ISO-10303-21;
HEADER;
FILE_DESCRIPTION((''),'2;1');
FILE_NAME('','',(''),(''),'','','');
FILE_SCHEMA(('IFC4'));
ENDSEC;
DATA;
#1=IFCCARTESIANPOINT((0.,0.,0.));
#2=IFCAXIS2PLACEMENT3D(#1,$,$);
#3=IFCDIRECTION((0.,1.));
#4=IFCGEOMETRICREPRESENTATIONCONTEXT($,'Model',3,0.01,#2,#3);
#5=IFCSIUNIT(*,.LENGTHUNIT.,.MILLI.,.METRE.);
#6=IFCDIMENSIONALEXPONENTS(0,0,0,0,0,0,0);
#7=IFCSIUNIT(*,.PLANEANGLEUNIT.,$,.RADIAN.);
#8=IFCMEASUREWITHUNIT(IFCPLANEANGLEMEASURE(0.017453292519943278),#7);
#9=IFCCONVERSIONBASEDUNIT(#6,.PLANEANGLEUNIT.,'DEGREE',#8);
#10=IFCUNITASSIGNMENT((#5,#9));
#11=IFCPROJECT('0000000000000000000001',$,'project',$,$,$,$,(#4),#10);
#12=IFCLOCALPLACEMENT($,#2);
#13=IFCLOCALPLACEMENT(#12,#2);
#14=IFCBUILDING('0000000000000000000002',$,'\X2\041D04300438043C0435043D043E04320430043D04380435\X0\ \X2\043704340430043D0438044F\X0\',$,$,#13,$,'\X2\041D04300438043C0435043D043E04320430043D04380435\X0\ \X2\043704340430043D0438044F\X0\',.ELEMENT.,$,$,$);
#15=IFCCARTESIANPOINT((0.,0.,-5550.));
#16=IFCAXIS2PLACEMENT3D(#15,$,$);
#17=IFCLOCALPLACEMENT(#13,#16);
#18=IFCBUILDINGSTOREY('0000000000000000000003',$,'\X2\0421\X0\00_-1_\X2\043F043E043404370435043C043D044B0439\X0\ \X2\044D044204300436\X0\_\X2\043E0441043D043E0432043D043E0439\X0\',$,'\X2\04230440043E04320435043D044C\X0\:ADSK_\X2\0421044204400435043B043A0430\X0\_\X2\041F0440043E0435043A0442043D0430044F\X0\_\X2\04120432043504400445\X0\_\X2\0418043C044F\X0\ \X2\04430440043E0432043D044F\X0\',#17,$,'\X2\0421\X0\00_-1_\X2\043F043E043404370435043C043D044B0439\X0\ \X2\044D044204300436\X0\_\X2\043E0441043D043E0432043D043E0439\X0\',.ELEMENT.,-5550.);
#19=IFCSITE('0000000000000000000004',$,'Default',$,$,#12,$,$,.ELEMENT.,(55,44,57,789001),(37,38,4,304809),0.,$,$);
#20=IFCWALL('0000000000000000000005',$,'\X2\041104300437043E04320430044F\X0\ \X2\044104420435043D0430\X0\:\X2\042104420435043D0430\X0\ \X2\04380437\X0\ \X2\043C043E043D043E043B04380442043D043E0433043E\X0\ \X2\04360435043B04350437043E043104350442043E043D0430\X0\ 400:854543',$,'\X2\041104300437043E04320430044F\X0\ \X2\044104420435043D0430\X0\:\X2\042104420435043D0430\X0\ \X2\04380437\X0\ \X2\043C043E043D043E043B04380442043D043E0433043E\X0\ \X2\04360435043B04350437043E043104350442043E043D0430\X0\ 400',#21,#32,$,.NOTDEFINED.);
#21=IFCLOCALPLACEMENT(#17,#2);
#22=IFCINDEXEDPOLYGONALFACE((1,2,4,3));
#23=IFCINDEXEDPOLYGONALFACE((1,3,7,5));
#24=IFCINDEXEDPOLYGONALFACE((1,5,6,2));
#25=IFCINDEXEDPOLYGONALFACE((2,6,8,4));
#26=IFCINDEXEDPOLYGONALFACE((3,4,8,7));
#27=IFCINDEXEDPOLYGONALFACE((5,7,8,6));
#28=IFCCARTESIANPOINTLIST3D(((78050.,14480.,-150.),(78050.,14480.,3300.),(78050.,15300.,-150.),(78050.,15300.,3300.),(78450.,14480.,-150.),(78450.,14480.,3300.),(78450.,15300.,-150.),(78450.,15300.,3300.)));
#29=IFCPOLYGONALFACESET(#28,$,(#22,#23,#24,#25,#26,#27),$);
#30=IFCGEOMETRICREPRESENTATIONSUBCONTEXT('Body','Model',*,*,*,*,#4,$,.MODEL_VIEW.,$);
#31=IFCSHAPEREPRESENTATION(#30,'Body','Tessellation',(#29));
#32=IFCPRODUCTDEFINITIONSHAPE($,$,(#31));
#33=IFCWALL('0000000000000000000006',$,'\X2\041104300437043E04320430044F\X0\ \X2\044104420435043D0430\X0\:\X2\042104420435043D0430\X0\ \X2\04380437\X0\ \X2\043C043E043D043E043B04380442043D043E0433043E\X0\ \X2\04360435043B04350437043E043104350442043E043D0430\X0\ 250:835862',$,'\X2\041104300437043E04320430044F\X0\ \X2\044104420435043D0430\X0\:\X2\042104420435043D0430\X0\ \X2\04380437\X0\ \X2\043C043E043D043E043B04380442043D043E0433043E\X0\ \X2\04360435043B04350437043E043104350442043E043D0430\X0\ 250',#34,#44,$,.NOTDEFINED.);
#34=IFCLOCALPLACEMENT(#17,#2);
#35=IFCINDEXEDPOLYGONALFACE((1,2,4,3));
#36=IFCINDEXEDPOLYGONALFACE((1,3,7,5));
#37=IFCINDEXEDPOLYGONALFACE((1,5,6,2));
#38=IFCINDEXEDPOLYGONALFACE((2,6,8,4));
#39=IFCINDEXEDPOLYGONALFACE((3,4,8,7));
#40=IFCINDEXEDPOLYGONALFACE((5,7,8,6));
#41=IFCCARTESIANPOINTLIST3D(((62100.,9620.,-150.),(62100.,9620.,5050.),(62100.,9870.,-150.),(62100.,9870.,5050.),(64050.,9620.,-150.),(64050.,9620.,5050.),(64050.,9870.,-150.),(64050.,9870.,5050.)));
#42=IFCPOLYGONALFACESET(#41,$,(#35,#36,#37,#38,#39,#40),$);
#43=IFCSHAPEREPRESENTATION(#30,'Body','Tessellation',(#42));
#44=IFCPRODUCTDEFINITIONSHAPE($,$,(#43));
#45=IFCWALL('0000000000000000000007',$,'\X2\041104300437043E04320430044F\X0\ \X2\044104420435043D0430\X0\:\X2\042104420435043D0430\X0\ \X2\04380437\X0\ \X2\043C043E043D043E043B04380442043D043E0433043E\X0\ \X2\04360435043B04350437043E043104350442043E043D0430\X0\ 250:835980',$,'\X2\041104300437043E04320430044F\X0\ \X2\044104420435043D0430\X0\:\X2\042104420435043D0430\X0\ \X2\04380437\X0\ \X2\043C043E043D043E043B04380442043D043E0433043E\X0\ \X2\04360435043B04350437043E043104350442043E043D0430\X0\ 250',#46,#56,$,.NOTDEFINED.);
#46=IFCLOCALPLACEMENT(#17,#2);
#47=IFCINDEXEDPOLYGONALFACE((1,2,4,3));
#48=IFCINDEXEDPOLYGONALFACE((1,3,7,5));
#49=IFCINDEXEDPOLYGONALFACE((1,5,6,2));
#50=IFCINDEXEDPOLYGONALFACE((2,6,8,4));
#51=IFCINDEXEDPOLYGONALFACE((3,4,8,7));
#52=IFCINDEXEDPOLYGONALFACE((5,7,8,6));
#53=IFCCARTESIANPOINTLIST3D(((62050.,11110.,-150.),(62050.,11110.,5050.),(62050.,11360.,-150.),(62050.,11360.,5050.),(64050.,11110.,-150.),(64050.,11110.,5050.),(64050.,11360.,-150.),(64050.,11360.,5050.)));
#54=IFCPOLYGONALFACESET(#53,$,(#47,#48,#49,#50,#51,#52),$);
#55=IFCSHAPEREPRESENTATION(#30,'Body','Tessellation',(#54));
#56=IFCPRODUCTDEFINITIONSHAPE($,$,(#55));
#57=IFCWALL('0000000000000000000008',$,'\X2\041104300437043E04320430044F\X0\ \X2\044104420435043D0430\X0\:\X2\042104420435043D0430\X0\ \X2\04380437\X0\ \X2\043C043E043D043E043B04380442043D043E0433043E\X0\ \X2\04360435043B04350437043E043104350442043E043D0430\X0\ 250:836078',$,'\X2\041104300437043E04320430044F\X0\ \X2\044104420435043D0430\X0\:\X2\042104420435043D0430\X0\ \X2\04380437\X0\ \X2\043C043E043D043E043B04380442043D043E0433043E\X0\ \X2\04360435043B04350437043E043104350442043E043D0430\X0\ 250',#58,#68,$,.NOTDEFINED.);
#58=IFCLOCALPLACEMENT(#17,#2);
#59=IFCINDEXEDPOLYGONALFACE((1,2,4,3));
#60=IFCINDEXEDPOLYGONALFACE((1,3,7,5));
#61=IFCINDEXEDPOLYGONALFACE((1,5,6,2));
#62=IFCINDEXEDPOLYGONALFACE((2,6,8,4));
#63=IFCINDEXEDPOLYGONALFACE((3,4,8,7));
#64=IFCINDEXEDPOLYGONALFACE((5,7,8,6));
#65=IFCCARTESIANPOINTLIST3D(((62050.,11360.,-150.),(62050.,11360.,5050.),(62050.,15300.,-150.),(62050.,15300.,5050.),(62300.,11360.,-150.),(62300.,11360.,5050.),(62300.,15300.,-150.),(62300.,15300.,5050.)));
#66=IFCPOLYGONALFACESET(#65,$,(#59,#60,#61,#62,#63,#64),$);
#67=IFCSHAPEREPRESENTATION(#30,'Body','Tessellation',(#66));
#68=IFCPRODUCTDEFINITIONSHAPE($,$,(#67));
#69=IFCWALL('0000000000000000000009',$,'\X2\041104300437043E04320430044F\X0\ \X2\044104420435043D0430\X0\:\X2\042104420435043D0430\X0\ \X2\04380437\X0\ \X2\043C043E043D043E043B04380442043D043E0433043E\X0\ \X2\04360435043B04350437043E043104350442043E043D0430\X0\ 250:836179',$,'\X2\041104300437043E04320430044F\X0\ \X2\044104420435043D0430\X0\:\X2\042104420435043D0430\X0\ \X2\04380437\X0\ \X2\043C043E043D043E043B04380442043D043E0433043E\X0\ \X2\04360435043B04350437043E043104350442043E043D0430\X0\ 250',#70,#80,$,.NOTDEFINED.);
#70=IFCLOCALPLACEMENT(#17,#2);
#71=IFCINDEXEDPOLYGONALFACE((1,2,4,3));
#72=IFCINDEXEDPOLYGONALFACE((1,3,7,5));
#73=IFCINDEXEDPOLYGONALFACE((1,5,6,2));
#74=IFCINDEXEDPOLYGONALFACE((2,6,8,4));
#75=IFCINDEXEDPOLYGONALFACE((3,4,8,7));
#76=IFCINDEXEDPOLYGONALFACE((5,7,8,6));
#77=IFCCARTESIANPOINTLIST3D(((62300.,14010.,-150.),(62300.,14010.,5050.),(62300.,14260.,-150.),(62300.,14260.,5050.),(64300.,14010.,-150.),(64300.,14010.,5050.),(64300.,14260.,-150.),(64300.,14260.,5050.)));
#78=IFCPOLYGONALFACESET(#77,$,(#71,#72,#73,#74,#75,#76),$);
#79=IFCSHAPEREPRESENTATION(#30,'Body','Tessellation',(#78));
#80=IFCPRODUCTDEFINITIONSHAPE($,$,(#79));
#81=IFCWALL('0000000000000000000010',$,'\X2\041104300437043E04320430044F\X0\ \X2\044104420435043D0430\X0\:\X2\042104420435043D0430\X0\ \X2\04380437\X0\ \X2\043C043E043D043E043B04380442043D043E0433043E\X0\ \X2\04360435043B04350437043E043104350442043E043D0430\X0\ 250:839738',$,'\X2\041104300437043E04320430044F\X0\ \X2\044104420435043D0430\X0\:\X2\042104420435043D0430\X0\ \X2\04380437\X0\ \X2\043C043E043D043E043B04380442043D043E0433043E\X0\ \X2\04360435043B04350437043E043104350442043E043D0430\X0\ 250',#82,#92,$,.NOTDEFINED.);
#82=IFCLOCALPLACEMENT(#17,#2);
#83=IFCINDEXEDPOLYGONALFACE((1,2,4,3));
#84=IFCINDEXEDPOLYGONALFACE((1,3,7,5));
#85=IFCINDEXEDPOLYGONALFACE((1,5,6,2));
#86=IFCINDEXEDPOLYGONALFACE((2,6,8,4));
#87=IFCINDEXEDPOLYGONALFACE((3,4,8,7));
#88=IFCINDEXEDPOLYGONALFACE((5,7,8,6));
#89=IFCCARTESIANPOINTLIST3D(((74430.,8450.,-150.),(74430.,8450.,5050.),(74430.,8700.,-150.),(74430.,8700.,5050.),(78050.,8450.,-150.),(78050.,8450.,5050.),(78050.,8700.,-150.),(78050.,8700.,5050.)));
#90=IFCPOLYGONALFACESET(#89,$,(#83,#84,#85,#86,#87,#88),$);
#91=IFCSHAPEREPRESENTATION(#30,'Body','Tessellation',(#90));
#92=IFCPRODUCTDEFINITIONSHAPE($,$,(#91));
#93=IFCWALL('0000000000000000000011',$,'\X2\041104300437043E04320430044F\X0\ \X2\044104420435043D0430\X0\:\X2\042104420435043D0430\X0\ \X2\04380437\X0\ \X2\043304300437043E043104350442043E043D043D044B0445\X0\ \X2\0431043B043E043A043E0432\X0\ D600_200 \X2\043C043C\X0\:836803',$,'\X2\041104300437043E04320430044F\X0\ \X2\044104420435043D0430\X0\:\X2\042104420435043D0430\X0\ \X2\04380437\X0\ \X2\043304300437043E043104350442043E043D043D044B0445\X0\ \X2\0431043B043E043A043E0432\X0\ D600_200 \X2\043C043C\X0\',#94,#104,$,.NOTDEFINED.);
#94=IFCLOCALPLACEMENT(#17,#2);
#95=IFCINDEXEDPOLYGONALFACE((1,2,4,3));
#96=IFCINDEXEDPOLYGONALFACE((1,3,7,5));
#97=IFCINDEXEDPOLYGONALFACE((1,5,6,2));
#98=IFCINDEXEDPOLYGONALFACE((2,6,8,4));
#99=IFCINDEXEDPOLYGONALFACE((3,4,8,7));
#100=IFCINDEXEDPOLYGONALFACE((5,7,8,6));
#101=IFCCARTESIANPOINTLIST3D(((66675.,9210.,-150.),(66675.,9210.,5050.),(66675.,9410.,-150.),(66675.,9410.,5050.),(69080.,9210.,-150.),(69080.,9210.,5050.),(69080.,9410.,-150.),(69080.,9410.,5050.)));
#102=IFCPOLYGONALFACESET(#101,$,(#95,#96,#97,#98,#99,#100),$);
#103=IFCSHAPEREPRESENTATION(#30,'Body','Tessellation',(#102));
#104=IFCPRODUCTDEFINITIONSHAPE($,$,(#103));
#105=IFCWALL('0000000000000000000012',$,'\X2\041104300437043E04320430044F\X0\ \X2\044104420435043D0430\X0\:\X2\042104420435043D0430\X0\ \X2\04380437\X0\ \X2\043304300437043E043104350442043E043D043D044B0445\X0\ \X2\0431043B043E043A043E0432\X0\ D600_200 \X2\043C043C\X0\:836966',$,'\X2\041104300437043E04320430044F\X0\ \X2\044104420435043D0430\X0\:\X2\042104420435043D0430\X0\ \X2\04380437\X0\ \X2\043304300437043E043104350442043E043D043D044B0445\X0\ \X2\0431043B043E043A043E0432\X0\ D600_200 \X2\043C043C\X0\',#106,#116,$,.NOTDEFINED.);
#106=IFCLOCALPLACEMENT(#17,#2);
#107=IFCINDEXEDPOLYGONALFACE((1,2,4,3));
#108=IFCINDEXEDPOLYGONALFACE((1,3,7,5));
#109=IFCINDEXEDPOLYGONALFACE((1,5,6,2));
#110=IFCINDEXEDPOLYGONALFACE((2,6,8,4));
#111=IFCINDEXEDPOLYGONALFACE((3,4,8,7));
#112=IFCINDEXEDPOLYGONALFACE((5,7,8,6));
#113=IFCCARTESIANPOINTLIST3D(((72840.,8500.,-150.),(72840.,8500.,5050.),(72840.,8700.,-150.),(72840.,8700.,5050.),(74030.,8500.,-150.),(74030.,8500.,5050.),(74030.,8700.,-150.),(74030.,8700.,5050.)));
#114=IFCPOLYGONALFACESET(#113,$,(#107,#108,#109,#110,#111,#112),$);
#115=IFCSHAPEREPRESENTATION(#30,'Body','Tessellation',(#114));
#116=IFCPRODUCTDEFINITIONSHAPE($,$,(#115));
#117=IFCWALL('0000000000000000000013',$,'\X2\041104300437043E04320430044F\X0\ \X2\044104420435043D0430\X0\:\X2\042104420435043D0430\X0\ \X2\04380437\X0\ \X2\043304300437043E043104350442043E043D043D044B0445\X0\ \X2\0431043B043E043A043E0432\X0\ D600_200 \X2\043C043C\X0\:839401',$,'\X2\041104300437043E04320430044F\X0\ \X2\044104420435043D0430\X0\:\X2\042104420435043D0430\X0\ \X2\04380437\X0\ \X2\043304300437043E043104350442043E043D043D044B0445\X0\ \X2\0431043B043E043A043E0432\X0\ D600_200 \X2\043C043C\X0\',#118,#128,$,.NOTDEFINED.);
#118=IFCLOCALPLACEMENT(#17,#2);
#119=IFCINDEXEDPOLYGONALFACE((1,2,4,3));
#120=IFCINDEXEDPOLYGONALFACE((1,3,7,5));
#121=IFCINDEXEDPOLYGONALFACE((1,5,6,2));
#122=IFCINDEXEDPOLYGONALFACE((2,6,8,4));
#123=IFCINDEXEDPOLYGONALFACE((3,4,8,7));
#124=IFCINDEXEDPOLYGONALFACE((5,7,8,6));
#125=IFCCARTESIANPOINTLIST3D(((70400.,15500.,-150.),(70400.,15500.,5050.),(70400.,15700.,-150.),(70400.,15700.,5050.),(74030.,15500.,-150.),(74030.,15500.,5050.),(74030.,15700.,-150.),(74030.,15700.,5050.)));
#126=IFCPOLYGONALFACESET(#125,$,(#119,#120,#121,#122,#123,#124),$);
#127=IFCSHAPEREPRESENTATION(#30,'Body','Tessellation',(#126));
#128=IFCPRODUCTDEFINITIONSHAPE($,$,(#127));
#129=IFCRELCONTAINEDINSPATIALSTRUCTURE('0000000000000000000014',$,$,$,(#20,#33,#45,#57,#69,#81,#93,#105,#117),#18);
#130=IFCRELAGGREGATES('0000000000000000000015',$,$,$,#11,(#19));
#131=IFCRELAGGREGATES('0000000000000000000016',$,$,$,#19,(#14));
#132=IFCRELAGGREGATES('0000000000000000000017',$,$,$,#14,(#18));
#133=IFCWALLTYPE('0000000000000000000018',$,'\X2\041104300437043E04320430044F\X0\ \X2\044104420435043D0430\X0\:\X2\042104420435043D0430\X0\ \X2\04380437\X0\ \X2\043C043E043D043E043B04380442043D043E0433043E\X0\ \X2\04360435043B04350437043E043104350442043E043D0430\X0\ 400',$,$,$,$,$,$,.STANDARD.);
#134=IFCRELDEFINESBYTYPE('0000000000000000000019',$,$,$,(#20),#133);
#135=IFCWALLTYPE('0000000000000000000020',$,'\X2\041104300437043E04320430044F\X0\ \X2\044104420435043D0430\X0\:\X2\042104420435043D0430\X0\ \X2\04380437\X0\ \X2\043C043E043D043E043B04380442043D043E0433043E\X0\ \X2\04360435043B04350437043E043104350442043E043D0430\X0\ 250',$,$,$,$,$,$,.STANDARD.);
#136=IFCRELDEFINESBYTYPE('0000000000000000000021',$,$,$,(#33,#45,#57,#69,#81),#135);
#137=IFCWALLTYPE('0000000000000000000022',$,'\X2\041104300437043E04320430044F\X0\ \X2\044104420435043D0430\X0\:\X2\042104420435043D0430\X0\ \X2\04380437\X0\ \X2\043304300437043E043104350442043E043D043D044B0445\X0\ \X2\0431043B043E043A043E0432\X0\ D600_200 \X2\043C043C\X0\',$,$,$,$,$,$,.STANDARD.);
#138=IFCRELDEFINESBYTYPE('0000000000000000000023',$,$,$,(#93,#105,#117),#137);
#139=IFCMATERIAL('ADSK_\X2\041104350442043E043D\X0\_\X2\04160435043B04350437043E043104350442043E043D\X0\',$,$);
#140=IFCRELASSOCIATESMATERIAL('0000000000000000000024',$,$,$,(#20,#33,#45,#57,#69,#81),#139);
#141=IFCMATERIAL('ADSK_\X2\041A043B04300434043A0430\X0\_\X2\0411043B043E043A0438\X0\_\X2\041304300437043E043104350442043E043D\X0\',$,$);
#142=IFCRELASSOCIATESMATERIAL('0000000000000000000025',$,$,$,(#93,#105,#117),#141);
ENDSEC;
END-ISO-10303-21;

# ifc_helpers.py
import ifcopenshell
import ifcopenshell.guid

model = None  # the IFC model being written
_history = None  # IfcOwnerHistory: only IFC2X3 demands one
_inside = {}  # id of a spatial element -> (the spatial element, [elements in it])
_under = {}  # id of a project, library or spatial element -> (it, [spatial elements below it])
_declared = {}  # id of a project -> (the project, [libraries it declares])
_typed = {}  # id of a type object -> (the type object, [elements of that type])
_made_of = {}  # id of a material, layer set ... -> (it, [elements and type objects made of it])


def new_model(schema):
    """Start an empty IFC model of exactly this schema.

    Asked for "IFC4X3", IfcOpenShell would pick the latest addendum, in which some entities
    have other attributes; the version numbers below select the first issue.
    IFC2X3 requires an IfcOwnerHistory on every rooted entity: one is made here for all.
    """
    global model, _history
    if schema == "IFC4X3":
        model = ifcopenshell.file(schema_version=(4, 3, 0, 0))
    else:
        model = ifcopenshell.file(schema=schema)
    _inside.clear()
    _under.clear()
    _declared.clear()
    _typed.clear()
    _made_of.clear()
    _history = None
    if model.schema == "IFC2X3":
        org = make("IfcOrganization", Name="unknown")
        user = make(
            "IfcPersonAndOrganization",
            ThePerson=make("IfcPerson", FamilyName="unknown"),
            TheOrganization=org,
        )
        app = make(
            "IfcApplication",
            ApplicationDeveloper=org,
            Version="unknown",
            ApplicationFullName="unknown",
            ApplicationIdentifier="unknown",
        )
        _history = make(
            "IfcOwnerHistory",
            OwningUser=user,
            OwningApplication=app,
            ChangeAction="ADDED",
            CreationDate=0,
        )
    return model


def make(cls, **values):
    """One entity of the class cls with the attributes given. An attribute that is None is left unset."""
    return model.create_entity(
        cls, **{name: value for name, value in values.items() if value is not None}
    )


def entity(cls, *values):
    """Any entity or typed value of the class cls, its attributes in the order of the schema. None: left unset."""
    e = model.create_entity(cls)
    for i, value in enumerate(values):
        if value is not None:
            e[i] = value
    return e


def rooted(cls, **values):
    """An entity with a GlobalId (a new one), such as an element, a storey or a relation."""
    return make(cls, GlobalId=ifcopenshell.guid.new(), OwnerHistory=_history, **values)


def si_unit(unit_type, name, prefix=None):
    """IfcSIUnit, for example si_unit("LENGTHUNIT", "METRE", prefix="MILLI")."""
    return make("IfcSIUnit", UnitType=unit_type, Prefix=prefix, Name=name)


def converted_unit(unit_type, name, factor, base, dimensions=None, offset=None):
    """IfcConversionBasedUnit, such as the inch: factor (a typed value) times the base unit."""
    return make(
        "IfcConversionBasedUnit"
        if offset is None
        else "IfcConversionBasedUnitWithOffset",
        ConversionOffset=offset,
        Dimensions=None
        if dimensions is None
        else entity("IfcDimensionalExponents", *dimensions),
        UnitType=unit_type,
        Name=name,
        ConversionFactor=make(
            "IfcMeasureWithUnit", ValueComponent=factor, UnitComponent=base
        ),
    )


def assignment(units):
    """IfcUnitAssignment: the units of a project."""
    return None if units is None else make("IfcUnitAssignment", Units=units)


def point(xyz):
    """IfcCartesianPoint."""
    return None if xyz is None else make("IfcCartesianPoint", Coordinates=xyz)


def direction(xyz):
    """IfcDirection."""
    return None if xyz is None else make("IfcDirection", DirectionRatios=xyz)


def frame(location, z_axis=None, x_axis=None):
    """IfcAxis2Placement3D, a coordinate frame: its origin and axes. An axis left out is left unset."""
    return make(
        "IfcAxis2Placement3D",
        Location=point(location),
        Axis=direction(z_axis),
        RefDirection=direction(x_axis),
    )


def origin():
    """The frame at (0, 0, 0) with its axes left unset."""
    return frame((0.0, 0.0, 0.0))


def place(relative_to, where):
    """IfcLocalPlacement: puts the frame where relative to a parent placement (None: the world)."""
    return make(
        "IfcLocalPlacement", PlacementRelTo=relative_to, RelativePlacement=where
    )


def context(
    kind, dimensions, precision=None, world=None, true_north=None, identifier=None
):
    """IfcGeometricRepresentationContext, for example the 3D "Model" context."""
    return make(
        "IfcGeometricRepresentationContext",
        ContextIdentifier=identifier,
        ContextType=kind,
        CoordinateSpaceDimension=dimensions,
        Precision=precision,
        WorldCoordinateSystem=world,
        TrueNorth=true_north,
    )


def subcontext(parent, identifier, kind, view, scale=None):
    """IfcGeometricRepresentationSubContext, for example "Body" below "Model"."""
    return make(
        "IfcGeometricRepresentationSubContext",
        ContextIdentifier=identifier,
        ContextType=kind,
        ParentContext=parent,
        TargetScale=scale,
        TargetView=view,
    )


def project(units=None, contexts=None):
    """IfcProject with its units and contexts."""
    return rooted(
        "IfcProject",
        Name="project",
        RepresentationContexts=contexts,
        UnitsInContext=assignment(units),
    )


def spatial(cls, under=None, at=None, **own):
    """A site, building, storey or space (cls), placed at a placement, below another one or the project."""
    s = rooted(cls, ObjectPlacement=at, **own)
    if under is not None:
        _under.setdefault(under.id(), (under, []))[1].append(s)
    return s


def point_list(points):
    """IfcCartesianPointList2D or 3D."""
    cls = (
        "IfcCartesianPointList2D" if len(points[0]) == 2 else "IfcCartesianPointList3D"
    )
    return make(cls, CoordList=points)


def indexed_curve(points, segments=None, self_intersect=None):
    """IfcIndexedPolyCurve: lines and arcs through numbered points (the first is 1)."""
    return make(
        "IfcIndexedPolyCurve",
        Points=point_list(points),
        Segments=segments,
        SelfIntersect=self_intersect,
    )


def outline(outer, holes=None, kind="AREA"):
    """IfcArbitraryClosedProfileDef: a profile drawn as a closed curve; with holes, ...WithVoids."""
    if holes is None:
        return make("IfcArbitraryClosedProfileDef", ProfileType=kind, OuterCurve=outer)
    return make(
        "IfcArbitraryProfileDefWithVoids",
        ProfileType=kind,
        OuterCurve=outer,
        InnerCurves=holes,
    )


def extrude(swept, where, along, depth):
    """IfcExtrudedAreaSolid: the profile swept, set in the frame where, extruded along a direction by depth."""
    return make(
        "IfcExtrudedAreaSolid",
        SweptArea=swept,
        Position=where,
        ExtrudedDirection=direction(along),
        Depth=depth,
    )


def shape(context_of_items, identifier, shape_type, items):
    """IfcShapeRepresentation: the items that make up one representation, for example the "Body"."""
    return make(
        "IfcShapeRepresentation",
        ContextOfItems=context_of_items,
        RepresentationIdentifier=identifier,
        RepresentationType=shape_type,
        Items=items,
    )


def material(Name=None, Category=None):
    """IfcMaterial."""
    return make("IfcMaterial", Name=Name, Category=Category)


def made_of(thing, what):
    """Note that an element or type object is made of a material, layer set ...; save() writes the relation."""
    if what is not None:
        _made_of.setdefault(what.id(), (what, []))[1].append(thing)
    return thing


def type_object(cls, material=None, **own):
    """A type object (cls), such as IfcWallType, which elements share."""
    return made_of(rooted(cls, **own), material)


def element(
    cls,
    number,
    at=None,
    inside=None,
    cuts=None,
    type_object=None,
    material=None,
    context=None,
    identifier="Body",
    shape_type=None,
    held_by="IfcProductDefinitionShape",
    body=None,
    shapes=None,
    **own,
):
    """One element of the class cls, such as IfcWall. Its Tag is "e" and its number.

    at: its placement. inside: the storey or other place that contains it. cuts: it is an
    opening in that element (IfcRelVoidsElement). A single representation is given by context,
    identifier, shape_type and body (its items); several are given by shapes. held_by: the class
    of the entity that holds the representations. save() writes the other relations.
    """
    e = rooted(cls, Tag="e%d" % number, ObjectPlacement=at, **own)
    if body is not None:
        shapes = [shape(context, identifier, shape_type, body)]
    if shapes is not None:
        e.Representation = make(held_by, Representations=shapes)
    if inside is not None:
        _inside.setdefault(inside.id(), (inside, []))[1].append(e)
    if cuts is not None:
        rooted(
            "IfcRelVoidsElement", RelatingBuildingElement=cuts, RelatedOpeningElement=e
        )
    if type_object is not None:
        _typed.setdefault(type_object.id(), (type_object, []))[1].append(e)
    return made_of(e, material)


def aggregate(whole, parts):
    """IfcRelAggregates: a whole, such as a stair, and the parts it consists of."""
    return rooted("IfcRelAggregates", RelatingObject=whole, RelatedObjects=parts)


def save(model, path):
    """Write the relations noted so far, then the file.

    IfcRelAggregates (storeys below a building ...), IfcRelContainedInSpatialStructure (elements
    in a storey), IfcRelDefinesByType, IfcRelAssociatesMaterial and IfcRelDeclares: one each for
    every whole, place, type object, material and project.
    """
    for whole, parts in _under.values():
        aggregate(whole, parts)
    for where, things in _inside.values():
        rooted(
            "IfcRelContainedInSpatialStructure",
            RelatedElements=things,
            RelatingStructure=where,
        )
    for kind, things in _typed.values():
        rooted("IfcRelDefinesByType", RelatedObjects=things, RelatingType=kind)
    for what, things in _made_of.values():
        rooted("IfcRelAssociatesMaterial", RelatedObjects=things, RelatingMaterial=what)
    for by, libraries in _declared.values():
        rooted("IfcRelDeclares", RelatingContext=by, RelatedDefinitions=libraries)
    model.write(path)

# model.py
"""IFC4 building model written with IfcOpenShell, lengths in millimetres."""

from ifc_helpers import new_model, entity, si_unit, converted_unit, direction, frame, origin, place, context, subcontext, project, spatial, indexed_curve, outline, extrude, material, type_object, element, save


model = new_model("IFC4")

# Units and contexts
model_context = context("Model", 3, precision=0.01, world=origin(), true_north=direction((0.0, 1.0)))
body_context = subcontext(model_context, "Body", "Model", "MODEL_VIEW")
ifc_project = project(units=[si_unit("LENGTHUNIT", "METRE", prefix="MILLI"), converted_unit("PLANEANGLEUNIT", "DEGREE", entity("IfcPlaneAngleMeasure", 0.017453292519943278), si_unit("PLANEANGLEUNIT", "RADIAN"), dimensions=[0, 0, 0, 0, 0, 0, 0])], contexts=[model_context])

# Site, building, storey
site_placement = place(None, origin())
site = spatial("IfcSite", under=ifc_project, at=site_placement, Name="Default", CompositionType="ELEMENT", RefLatitude=(55, 44, 57, 789001), RefLongitude=(37, 38, 4, 304809), RefElevation=0.0)
building_placement = place(site_placement, origin())
building = spatial("IfcBuilding", under=site, at=building_placement, Name="Наименование здания", LongName="Наименование здания", CompositionType="ELEMENT")
storey_placement = place(building_placement, frame((0.0, 0.0, -5550.0)))
storey = spatial("IfcBuildingStorey", under=building, at=storey_placement, Name="С00_-1_подземный этаж_основной", ObjectType="Уровень:ADSK_Стрелка_Проектная_Вверх_Имя уровня", LongName="С00_-1_подземный этаж_основной", CompositionType="ELEMENT", Elevation=-5550.0)

# Shared definitions
ifc_material_1 = material(Name="ADSK_Бетон_Железобетон")

# Walls
wall_type_1 = type_object("IfcWallType", Name="Базовая стена:Стена из монолитного железобетона 400", PredefinedType="STANDARD")
wall_1_placement = place(storey_placement, frame((78250.0, 14480.0, -150.0), z_axis=(0.0, 0.0, 1.0), x_axis=(0.0, 1.0, 0.0)))
element("IfcWall", 1, at=wall_1_placement, inside=storey, type_object=wall_type_1, material=ifc_material_1, Name="Базовая стена:Стена из монолитного железобетона 400:854543", ObjectType="Базовая стена:Стена из монолитного железобетона 400", PredefinedType="NOTDEFINED", context=body_context, shape_type="SweptSolid", body=[
    extrude(outline(indexed_curve([(820.0, 200.0), (0.0, 200.0), (0.0, -200.0), (820.0, -200.0), (820.0, 200.0)], self_intersect=False)), origin(), (0.0, 0.0, 1.0), 3450.0),
])
wall_type_2 = type_object("IfcWallType", Name="Базовая стена:Стена из монолитного железобетона 250", PredefinedType="STANDARD")
wall_2_placement = place(storey_placement, frame((62100.0, 9745.0, -150.0)))
element("IfcWall", 2, at=wall_2_placement, inside=storey, type_object=wall_type_2, material=ifc_material_1, Name="Базовая стена:Стена из монолитного железобетона 250:835862", ObjectType="Базовая стена:Стена из монолитного железобетона 250", PredefinedType="NOTDEFINED", context=body_context, shape_type="SweptSolid", body=[
    extrude(outline(indexed_curve([(1950.0, 125.0), (0.0, 125.0), (0.0, -125.0), (1950.0, -125.0), (1950.0, 125.0)], self_intersect=False)), origin(), (0.0, 0.0, 1.0), 5200.0),
])
wall_3_placement = place(storey_placement, frame((64050.0, 11235.0, -150.0), z_axis=(0.0, 0.0, 1.0), x_axis=(-1.0, 0.0, 0.0)))
element("IfcWall", 3, at=wall_3_placement, inside=storey, type_object=wall_type_2, material=ifc_material_1, Name="Базовая стена:Стена из монолитного железобетона 250:835980", ObjectType="Базовая стена:Стена из монолитного железобетона 250", PredefinedType="NOTDEFINED", context=body_context, shape_type="SweptSolid", body=[
    extrude(outline(indexed_curve([(2000.0, 125.0), (0.0, 125.0), (0.0, -125.0), (2000.0, -125.0), (2000.0, 125.0)], self_intersect=False)), origin(), (0.0, 0.0, 1.0), 5200.0),
])
wall_4_placement = place(storey_placement, frame((62175.0, 11360.0, -150.0), z_axis=(0.0, 0.0, 1.0), x_axis=(0.0, 1.0, 0.0)))
element("IfcWall", 4, at=wall_4_placement, inside=storey, type_object=wall_type_2, material=ifc_material_1, Name="Базовая стена:Стена из монолитного железобетона 250:836078", ObjectType="Базовая стена:Стена из монолитного железобетона 250", PredefinedType="NOTDEFINED", context=body_context, shape_type="SweptSolid", body=[
    extrude(outline(indexed_curve([(3940.0, 125.0), (0.0, 125.0), (0.0, -125.0), (3940.0, -125.0), (3940.0, 125.0)], self_intersect=False)), origin(), (0.0, 0.0, 1.0), 5200.0),
])
wall_5_placement = place(storey_placement, frame((64300.0, 14135.0, -150.0), z_axis=(0.0, 0.0, 1.0), x_axis=(-1.0, 0.0, 0.0)))
element("IfcWall", 5, at=wall_5_placement, inside=storey, type_object=wall_type_2, material=ifc_material_1, Name="Базовая стена:Стена из монолитного железобетона 250:836179", ObjectType="Базовая стена:Стена из монолитного железобетона 250", PredefinedType="NOTDEFINED", context=body_context, shape_type="SweptSolid", body=[
    extrude(outline(indexed_curve([(2000.0, 125.0), (0.0, 125.0), (0.0, -125.0), (2000.0, -125.0), (2000.0, 125.0)], self_intersect=False)), origin(), (0.0, 0.0, 1.0), 5200.0),
])
wall_6_placement = place(storey_placement, frame((74430.0, 8575.0, -150.0)))
element("IfcWall", 6, at=wall_6_placement, inside=storey, type_object=wall_type_2, material=ifc_material_1, Name="Базовая стена:Стена из монолитного железобетона 250:839738", ObjectType="Базовая стена:Стена из монолитного железобетона 250", PredefinedType="NOTDEFINED", context=body_context, shape_type="SweptSolid", body=[
    extrude(outline(indexed_curve([(3620.0, 125.0), (0.0, 125.0), (0.0, -125.0), (3620.0, -125.0), (3620.0, 125.0)], self_intersect=False)), origin(), (0.0, 0.0, 1.0), 5200.0),
])
ifc_material_2 = material(Name="ADSK_Кладка_Блоки_Газобетон")
wall_type_3 = type_object("IfcWallType", Name="Базовая стена:Стена из газобетонных блоков D600_200 мм", PredefinedType="STANDARD")
wall_7_placement = place(storey_placement, frame((69080.0, 9310.0, -150.0), z_axis=(0.0, 0.0, 1.0), x_axis=(-1.0, 0.0, 0.0)))
element("IfcWall", 7, at=wall_7_placement, inside=storey, type_object=wall_type_3, material=ifc_material_2, Name="Базовая стена:Стена из газобетонных блоков D600_200 мм:836803", ObjectType="Базовая стена:Стена из газобетонных блоков D600_200 мм", PredefinedType="NOTDEFINED", context=body_context, shape_type="SweptSolid", body=[
    extrude(outline(indexed_curve([(2405.0, 100.0), (0.0, 100.0), (0.0, -100.0), (2405.0, -100.0), (2405.0, 100.0)], self_intersect=False)), origin(), (0.0, 0.0, 1.0), 5200.0),
])
wall_8_placement = place(storey_placement, frame((72840.0, 8600.0, -150.0)))
element("IfcWall", 8, at=wall_8_placement, inside=storey, type_object=wall_type_3, material=ifc_material_2, Name="Базовая стена:Стена из газобетонных блоков D600_200 мм:836966", ObjectType="Базовая стена:Стена из газобетонных блоков D600_200 мм", PredefinedType="NOTDEFINED", context=body_context, shape_type="SweptSolid", body=[
    extrude(outline(indexed_curve([(1190.0, 100.0), (0.0, 100.0), (0.0, -100.0), (1190.0, -100.0), (1190.0, 100.0)], self_intersect=False)), origin(), (0.0, 0.0, 1.0), 5200.0),
])
wall_9_placement = place(storey_placement, frame((70400.0, 15600.0, -150.0)))
element("IfcWall", 9, at=wall_9_placement, inside=storey, type_object=wall_type_3, material=ifc_material_2, Name="Базовая стена:Стена из газобетонных блоков D600_200 мм:839401", ObjectType="Базовая стена:Стена из газобетонных блоков D600_200 мм", PredefinedType="NOTDEFINED", context=body_context, shape_type="SweptSolid", body=[
    extrude(outline(indexed_curve([(3630.0, 100.0), (0.0, 100.0), (0.0, -100.0), (3630.0, -100.0), (3630.0, 100.0)], self_intersect=False)), origin(), (0.0, 0.0, 1.0), 5200.0),
])

save(model, "model.ifc")
